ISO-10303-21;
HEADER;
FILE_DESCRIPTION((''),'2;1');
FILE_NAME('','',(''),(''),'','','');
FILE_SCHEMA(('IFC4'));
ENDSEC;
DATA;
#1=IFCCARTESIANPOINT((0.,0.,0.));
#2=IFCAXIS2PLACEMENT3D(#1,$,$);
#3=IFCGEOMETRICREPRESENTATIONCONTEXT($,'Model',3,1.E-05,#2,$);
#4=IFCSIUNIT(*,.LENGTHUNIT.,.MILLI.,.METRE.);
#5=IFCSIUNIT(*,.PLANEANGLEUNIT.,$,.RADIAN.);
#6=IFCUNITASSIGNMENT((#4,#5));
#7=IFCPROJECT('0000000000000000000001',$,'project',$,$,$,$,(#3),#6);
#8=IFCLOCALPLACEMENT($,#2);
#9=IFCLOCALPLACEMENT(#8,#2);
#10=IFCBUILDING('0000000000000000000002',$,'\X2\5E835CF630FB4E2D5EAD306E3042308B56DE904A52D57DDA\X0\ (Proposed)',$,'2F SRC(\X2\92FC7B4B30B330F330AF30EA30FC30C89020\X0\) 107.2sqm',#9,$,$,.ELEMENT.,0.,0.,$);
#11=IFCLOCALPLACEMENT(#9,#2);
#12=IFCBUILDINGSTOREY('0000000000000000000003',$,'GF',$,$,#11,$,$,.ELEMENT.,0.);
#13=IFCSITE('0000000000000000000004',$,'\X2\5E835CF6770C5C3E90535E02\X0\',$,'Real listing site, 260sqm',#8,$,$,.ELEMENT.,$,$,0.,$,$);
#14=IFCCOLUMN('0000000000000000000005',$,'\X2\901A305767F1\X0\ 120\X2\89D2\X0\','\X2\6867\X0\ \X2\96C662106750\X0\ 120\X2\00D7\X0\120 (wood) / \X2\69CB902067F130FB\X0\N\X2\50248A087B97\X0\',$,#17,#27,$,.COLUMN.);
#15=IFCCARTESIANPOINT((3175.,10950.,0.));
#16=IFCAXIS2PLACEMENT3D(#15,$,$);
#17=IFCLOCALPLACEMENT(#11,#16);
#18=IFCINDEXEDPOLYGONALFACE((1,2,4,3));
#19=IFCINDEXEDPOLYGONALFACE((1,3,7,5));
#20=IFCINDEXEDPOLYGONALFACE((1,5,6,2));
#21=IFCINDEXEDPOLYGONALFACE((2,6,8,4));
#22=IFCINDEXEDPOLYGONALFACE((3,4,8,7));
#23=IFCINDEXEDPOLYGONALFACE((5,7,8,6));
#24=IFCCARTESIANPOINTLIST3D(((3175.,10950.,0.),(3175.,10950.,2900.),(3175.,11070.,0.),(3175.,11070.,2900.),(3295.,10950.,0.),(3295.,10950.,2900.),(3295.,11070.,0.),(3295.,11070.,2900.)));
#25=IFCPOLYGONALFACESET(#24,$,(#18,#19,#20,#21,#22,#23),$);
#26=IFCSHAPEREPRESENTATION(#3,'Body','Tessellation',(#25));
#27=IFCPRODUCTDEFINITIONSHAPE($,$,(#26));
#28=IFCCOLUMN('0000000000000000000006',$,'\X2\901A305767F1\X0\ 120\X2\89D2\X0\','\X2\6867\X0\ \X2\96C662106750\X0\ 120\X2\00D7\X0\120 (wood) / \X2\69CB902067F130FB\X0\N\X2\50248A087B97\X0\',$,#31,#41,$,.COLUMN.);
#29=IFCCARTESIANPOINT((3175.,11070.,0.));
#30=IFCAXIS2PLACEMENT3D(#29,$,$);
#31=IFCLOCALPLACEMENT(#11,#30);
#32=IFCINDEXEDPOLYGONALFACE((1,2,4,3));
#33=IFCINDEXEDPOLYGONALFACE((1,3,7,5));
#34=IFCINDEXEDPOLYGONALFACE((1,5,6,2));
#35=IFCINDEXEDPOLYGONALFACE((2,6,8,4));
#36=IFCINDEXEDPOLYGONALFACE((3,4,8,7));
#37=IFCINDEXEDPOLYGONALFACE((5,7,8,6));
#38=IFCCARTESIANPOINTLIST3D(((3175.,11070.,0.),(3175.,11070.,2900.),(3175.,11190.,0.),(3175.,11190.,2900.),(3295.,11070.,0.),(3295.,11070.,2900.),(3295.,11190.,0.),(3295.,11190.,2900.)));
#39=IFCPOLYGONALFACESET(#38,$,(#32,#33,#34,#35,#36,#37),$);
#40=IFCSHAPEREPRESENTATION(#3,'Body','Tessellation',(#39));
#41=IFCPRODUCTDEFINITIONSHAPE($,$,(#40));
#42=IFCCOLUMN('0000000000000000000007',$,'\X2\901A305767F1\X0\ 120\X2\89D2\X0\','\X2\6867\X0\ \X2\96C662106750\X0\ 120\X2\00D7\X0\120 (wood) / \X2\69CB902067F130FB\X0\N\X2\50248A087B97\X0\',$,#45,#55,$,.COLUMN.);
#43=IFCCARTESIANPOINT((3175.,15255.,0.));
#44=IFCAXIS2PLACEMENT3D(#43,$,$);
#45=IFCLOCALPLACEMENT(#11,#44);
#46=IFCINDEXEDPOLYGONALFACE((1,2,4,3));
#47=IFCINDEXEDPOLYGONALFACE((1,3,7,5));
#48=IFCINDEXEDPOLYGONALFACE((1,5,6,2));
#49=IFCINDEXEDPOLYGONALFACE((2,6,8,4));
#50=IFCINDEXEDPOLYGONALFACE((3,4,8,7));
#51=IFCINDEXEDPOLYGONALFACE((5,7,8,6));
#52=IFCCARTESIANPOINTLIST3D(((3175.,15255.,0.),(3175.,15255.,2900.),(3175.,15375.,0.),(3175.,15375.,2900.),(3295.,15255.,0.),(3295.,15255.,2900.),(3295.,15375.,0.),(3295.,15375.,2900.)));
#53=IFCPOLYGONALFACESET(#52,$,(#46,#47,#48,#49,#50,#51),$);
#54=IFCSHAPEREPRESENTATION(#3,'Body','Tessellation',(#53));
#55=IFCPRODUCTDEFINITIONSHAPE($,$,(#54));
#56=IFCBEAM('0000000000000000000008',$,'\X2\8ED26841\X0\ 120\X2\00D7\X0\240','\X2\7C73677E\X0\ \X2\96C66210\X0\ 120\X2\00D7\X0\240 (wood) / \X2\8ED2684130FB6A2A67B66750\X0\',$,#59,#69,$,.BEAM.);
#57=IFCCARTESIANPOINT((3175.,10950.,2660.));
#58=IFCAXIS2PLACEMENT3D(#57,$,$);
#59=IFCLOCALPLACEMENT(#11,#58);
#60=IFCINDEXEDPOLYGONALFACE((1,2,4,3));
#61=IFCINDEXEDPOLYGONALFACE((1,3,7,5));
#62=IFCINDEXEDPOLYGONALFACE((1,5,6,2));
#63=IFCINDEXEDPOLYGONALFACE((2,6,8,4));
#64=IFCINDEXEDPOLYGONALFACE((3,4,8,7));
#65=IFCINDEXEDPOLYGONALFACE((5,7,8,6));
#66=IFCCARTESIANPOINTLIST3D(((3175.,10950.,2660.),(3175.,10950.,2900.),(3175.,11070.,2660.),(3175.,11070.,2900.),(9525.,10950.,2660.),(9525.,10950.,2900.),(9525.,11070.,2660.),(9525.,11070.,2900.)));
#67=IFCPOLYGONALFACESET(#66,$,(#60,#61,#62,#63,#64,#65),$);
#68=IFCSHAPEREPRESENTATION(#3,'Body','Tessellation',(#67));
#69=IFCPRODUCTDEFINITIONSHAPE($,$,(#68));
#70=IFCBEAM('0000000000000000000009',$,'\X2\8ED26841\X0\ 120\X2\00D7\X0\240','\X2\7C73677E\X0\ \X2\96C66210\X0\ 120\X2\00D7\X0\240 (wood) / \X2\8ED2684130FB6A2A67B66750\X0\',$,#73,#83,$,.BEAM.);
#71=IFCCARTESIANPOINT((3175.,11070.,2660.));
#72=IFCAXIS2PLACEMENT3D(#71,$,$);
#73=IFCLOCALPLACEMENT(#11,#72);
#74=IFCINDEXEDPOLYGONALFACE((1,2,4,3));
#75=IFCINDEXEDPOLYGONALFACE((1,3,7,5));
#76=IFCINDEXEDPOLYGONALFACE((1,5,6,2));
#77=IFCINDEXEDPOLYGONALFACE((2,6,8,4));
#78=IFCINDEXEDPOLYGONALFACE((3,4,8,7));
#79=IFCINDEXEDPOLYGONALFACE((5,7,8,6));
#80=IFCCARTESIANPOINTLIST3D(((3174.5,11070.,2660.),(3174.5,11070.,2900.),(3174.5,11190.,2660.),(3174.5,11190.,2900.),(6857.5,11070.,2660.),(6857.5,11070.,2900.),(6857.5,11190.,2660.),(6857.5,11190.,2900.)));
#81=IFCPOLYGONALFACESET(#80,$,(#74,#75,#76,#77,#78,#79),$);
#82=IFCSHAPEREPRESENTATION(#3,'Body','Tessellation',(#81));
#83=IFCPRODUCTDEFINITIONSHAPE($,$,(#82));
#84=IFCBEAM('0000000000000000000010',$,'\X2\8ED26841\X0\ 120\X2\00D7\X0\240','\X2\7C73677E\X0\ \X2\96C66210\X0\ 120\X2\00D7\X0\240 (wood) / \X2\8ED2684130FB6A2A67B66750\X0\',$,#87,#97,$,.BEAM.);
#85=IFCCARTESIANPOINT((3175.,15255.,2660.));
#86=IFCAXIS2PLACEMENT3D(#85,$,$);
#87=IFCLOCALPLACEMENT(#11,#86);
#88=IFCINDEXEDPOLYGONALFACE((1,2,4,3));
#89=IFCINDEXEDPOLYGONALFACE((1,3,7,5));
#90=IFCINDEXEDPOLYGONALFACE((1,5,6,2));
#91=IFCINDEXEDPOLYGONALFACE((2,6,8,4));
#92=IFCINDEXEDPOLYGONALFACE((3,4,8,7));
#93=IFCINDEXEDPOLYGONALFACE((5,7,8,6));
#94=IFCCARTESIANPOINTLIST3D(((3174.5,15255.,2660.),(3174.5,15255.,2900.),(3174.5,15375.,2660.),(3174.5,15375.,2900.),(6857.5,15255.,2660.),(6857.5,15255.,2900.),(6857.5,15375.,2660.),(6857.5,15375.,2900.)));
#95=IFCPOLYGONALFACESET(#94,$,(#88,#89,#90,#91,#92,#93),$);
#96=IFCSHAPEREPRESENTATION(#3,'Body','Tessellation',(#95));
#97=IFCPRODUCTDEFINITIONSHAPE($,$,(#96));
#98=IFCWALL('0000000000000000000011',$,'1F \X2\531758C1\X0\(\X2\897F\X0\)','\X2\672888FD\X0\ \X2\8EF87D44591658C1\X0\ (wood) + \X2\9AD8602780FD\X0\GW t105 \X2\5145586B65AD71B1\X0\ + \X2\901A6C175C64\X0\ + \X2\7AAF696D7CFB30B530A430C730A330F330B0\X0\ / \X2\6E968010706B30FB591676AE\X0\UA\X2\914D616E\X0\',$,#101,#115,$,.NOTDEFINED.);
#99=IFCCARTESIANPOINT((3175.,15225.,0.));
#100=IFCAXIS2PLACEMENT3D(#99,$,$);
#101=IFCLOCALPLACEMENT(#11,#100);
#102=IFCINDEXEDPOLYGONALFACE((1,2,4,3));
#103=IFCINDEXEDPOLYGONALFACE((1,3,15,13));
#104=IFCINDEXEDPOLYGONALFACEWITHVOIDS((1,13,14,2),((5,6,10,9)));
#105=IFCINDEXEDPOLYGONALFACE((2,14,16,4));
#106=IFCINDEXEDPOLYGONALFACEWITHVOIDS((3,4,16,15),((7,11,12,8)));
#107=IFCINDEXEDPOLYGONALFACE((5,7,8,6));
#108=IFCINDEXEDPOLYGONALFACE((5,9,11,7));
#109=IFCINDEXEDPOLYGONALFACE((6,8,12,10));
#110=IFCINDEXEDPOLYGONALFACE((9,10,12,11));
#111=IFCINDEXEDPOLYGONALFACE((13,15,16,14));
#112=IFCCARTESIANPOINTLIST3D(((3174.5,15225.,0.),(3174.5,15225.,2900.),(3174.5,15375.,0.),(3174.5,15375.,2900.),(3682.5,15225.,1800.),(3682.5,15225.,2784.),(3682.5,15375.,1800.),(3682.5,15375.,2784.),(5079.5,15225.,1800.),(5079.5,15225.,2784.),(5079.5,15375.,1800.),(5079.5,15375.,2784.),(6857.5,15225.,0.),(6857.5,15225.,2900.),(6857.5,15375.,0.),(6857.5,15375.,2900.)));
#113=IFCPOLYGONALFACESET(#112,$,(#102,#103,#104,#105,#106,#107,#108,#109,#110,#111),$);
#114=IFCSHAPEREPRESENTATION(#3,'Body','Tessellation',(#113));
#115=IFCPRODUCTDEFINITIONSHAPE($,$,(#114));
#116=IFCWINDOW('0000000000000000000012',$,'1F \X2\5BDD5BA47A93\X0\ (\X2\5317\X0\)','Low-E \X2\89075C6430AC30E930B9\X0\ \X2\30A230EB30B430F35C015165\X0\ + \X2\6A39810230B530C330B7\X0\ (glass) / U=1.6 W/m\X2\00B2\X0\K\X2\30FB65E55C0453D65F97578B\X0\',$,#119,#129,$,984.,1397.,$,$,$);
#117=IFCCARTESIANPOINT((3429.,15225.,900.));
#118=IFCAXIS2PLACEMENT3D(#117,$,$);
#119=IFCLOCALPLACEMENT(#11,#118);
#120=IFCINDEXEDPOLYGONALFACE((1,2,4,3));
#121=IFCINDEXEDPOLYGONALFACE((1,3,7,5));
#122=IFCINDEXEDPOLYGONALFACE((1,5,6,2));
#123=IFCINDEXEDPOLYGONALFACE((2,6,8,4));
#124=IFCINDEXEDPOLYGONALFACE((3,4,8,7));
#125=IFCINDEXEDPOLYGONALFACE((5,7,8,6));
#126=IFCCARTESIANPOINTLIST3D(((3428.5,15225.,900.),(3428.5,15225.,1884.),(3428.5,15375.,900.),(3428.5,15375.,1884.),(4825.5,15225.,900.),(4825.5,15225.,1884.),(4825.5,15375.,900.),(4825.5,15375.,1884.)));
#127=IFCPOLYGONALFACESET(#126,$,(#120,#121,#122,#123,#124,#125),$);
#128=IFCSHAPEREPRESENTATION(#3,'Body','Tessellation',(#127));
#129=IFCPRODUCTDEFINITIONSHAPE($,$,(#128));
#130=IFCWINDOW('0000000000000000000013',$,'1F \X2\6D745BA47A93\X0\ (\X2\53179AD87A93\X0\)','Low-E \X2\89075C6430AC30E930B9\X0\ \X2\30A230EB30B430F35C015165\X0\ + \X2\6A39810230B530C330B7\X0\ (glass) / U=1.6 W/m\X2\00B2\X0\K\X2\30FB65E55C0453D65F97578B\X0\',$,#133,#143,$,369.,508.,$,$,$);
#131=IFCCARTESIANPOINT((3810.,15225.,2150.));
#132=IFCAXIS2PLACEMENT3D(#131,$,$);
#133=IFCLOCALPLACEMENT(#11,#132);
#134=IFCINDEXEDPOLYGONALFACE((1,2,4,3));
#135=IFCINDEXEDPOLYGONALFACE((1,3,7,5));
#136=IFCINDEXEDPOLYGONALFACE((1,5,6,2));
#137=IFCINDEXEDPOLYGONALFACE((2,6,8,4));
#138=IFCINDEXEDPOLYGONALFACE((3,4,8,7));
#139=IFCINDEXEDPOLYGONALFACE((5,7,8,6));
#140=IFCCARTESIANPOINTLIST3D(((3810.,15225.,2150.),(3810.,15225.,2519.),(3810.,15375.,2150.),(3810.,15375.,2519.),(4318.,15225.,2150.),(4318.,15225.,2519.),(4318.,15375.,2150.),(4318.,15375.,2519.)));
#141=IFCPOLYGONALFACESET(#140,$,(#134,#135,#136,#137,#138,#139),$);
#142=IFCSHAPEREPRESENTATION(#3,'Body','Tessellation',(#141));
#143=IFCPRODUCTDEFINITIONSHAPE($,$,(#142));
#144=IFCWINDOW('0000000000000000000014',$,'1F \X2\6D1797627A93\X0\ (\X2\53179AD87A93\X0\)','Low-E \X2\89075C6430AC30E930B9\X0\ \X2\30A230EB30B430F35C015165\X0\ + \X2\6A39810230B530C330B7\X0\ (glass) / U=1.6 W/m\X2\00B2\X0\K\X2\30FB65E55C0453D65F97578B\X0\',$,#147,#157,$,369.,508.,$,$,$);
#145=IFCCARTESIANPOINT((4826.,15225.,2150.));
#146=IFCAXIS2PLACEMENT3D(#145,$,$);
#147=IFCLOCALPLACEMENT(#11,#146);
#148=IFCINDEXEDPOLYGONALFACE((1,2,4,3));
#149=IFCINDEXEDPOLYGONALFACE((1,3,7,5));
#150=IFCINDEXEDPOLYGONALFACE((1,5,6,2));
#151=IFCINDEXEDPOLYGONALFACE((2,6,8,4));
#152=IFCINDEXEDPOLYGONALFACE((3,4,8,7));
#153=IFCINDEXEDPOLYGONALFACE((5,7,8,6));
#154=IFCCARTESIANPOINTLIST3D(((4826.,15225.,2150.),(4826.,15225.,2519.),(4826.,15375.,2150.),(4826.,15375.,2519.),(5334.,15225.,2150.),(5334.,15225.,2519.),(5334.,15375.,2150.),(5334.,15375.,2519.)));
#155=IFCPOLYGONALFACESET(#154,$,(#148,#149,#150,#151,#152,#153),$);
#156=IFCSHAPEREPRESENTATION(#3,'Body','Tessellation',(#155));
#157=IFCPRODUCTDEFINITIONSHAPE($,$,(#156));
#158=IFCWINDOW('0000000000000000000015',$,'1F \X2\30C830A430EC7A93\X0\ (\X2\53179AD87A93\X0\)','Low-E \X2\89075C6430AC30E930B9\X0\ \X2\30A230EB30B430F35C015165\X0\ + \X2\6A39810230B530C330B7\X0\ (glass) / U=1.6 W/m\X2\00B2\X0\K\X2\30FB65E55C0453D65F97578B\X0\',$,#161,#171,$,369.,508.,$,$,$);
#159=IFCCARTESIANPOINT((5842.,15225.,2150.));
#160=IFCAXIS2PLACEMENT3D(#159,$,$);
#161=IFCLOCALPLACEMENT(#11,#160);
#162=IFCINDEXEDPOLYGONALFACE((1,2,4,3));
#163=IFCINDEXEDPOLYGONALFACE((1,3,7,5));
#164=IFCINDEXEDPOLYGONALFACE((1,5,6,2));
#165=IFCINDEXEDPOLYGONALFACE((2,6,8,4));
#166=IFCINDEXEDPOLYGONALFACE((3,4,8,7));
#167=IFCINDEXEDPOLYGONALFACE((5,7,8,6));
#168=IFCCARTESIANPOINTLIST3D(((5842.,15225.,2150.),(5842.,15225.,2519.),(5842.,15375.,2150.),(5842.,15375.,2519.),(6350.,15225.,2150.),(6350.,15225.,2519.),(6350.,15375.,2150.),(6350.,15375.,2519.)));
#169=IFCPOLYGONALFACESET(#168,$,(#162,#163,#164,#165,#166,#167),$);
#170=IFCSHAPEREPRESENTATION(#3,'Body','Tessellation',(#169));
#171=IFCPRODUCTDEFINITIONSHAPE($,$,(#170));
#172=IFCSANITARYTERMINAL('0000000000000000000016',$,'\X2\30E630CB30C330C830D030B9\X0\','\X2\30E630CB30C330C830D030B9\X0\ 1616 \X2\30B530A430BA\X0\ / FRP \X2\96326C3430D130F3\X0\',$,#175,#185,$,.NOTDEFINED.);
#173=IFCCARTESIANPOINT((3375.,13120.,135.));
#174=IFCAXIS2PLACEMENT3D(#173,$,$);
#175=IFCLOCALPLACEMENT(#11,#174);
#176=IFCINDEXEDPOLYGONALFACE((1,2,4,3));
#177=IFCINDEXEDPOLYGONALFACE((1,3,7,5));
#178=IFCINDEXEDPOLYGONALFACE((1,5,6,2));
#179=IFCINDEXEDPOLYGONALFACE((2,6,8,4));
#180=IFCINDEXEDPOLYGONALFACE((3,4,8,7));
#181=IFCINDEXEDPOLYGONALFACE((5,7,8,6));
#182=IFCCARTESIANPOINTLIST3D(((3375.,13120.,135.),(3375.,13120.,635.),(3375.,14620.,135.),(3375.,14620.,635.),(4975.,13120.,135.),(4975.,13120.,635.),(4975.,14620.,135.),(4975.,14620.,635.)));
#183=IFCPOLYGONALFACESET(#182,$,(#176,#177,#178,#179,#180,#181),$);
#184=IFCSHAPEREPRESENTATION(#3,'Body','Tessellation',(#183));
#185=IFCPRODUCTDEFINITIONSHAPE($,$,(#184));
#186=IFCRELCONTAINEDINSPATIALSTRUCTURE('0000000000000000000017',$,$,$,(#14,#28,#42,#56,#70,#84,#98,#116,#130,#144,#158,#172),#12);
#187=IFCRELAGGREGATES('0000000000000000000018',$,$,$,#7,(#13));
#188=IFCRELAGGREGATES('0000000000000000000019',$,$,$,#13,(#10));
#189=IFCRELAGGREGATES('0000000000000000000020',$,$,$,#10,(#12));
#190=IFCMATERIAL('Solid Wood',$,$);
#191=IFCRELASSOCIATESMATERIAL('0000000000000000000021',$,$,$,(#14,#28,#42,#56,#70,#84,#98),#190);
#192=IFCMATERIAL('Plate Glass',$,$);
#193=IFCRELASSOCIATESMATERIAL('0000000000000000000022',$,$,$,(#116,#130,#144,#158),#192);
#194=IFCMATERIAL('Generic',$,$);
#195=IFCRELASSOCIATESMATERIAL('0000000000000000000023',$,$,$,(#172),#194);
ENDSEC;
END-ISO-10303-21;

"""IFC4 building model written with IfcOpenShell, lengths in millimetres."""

from ifc_helpers import new_model, si_unit, frame, frame_2d, origin, place, context, project, spatial, rectangle, extrude, material, element, fill, save


model = new_model("IFC4")

# Units and contexts
model_context = context("Model", 3, precision=1e-05, world=origin())
ifc_project = project(units=[si_unit("LENGTHUNIT", "METRE", prefix="MILLI"), si_unit("PLANEANGLEUNIT", "RADIAN")], contexts=[model_context])

# Site, building, storey
site_placement = place(None, origin())
site = spatial("IfcSite", under=ifc_project, at=site_placement, Name="広島県尾道市", ObjectType="Real listing site, 260sqm", CompositionType="ELEMENT", RefElevation=0.0)
building_placement = place(site_placement, origin())
building = spatial("IfcBuilding", under=site, at=building_placement, Name="広島・中庭のある回遊動線 (Proposed)", ObjectType="2F SRC(鋼筋コンクリート造) 107.2sqm", CompositionType="ELEMENT", ElevationOfRefHeight=0.0, ElevationOfTerrain=0.0)
storey_placement = place(building_placement, origin())
storey = spatial("IfcBuildingStorey", under=building, at=storey_placement, Name="GF", CompositionType="ELEMENT", Elevation=0.0)

# Columns
ifc_material_1 = material(Name="Solid Wood")
column_1_placement = place(storey_placement, frame((3175.0, 10950.0, 0.0)))
element("IfcColumn", 1, at=column_1_placement, inside=storey, material=ifc_material_1, Name="通し柱 120角", Description="桧 集成材 120×120 (wood) / 構造柱・N値計算", PredefinedType="COLUMN", context=model_context, shape_type="SweptSolid", body=[
    extrude(rectangle(XDim=120.0, YDim=120.0, at=frame_2d((60.0, 60.0))), frame((3175.0, 10950.0, 0.0)), (0.0, 0.0, 1.0), 2900.0),
])
column_2_placement = place(storey_placement, frame((3175.0, 11070.0, 0.0)))
element("IfcColumn", 2, at=column_2_placement, inside=storey, material=ifc_material_1, Name="通し柱 120角", Description="桧 集成材 120×120 (wood) / 構造柱・N値計算", PredefinedType="COLUMN", context=model_context, shape_type="SweptSolid", body=[
    extrude(rectangle(XDim=120.0, YDim=120.0, at=frame_2d((60.0, 60.0))), frame((3175.0, 11070.0, 0.0)), (0.0, 0.0, 1.0), 2900.0),
])
column_3_placement = place(storey_placement, frame((3175.0, 15255.0, 0.0)))
element("IfcColumn", 3, at=column_3_placement, inside=storey, material=ifc_material_1, Name="通し柱 120角", Description="桧 集成材 120×120 (wood) / 構造柱・N値計算", PredefinedType="COLUMN", context=model_context, shape_type="SweptSolid", body=[
    extrude(rectangle(XDim=120.0, YDim=120.0, at=frame_2d((60.0, 60.0))), frame((3175.0, 15255.0, 0.0)), (0.0, 0.0, 1.0), 2900.0),
])

# Beams
beam_1_placement = place(storey_placement, frame((3175.0, 10950.0, 2660.0)))
element("IfcBeam", 4, at=beam_1_placement, inside=storey, material=ifc_material_1, Name="軒桁 120×240", Description="米松 集成 120×240 (wood) / 軒桁・横架材", PredefinedType="BEAM", context=model_context, shape_type="SweptSolid", body=[
    extrude(rectangle(XDim=6350.0, YDim=120.0, at=frame_2d((3175.0, 60.0))), frame((3175.0, 10950.0, 2660.0)), (0.0, 0.0, 1.0), 240.0),
])
beam_2_placement = place(storey_placement, frame((3175.0, 11070.0, 2660.0)))
element("IfcBeam", 5, at=beam_2_placement, inside=storey, material=ifc_material_1, Name="軒桁 120×240", Description="米松 集成 120×240 (wood) / 軒桁・横架材", PredefinedType="BEAM", context=model_context, shape_type="SweptSolid", body=[
    extrude(rectangle(XDim=3683.0, YDim=120.0, at=frame_2d((1841.0, 60.0))), frame((3175.0, 11070.0, 2660.0)), (0.0, 0.0, 1.0), 240.0),
])
beam_3_placement = place(storey_placement, frame((3175.0, 15255.0, 2660.0)))
element("IfcBeam", 6, at=beam_3_placement, inside=storey, material=ifc_material_1, Name="軒桁 120×240", Description="米松 集成 120×240 (wood) / 軒桁・横架材", PredefinedType="BEAM", context=model_context, shape_type="SweptSolid", body=[
    extrude(rectangle(XDim=3683.0, YDim=120.0, at=frame_2d((1841.0, 60.0))), frame((3175.0, 15255.0, 2660.0)), (0.0, 0.0, 1.0), 240.0),
])

# Wall, openings, windows
wall_1_placement = place(storey_placement, frame((3175.0, 15225.0, 0.0)))
wall_1 = element("IfcWall", 7, at=wall_1_placement, inside=storey, material=ifc_material_1, Name="1F 北壁(西)", Description="木製 軸組外壁 (wood) + 高性能GW t105 充填断熱 + 通気層 + 窯業系サイディング / 準耐火・外皮UA配慮", PredefinedType="NOTDEFINED", context=model_context, shape_type="SweptSolid", body=[
    extrude(rectangle(XDim=3683.0, YDim=150.0, at=frame_2d((1841.0, 75.0))), frame((3175.0, 15225.0, 0.0)), (0.0, 0.0, 1.0), 2900.0),
])
opening_1_placement = place(storey_placement, frame((3429.0, 15225.0, 900.0)))
opening_1 = element("IfcOpeningElement", 8, at=opening_1_placement, cuts=wall_1, PredefinedType="NOTDEFINED", context=model_context, shape_type="SweptSolid", body=[
    extrude(rectangle(XDim=1397.0, YDim=150.0, at=frame_2d((698.0, 75.0))), frame((3429.0, 15225.0, 900.0)), (0.0, 0.0, 1.0), 984.0),
])
opening_2_placement = place(storey_placement, frame((3810.0, 15225.0, 2150.0)))
opening_2 = element("IfcOpeningElement", 9, at=opening_2_placement, cuts=wall_1, PredefinedType="NOTDEFINED", context=model_context, shape_type="SweptSolid", body=[
    extrude(rectangle(XDim=508.0, YDim=150.0, at=frame_2d((254.0, 75.0))), frame((3810.0, 15225.0, 2150.0)), (0.0, 0.0, 1.0), 369.0),
])
opening_3_placement = place(storey_placement, frame((4826.0, 15225.0, 2150.0)))
opening_3 = element("IfcOpeningElement", 10, at=opening_3_placement, cuts=wall_1, PredefinedType="NOTDEFINED", context=model_context, shape_type="SweptSolid", body=[
    extrude(rectangle(XDim=508.0, YDim=150.0, at=frame_2d((254.0, 75.0))), frame((4826.0, 15225.0, 2150.0)), (0.0, 0.0, 1.0), 369.0),
])
opening_4_placement = place(storey_placement, frame((5842.0, 15225.0, 2150.0)))
opening_4 = element("IfcOpeningElement", 11, at=opening_4_placement, cuts=wall_1, PredefinedType="NOTDEFINED", context=model_context, shape_type="SweptSolid", body=[
    extrude(rectangle(XDim=508.0, YDim=150.0, at=frame_2d((254.0, 75.0))), frame((5842.0, 15225.0, 2150.0)), (0.0, 0.0, 1.0), 369.0),
])
ifc_material_2 = material(Name="Plate Glass")
window_1_placement = place(storey_placement, frame((3429.0, 15225.0, 900.0)))
window_1 = element("IfcWindow", 12, at=window_1_placement, inside=storey, material=ifc_material_2, Name="1F 寝室窓 (北)", Description="Low-E 複層ガラス アルゴン封入 + 樹脂サッシ (glass) / U=1.6 W/m²K・日射取得型", OverallHeight=984.0, OverallWidth=1397.0, context=model_context, shape_type="SweptSolid", body=[
    extrude(rectangle(XDim=1397.0, YDim=150.0, at=frame_2d((698.0, 75.0))), frame((3429.0, 15225.0, 900.0)), (0.0, 0.0, 1.0), 984.0),
])
fill(opening_1, window_1)
window_2_placement = place(storey_placement, frame((3810.0, 15225.0, 2150.0)))
window_2 = element("IfcWindow", 13, at=window_2_placement, inside=storey, material=ifc_material_2, Name="1F 浴室窓 (北高窓)", Description="Low-E 複層ガラス アルゴン封入 + 樹脂サッシ (glass) / U=1.6 W/m²K・日射取得型", OverallHeight=369.0, OverallWidth=508.0, context=model_context, shape_type="SweptSolid", body=[
    extrude(rectangle(XDim=508.0, YDim=150.0, at=frame_2d((254.0, 75.0))), frame((3810.0, 15225.0, 2150.0)), (0.0, 0.0, 1.0), 369.0),
])
fill(opening_2, window_2)
window_3_placement = place(storey_placement, frame((4826.0, 15225.0, 2150.0)))
window_3 = element("IfcWindow", 14, at=window_3_placement, inside=storey, material=ifc_material_2, Name="1F 洗面窓 (北高窓)", Description="Low-E 複層ガラス アルゴン封入 + 樹脂サッシ (glass) / U=1.6 W/m²K・日射取得型", OverallHeight=369.0, OverallWidth=508.0, context=model_context, shape_type="SweptSolid", body=[
    extrude(rectangle(XDim=508.0, YDim=150.0, at=frame_2d((254.0, 75.0))), frame((4826.0, 15225.0, 2150.0)), (0.0, 0.0, 1.0), 369.0),
])
fill(opening_3, window_3)
window_4_placement = place(storey_placement, frame((5842.0, 15225.0, 2150.0)))
window_4 = element("IfcWindow", 15, at=window_4_placement, inside=storey, material=ifc_material_2, Name="1F トイレ窓 (北高窓)", Description="Low-E 複層ガラス アルゴン封入 + 樹脂サッシ (glass) / U=1.6 W/m²K・日射取得型", OverallHeight=369.0, OverallWidth=508.0, context=model_context, shape_type="SweptSolid", body=[
    extrude(rectangle(XDim=508.0, YDim=150.0, at=frame_2d((254.0, 75.0))), frame((5842.0, 15225.0, 2150.0)), (0.0, 0.0, 1.0), 369.0),
])
fill(opening_4, window_4)

# Shared definitions
ifc_material_3 = material(Name="Generic")

# Sanitary terminal
sanitary_terminal_placement = place(storey_placement, frame((3375.0, 13120.0, 135.0)))
element("IfcSanitaryTerminal", 16, at=sanitary_terminal_placement, inside=storey, material=ifc_material_3, Name="ユニットバス", Description="ユニットバス 1616 サイズ / FRP 防水パン", PredefinedType="NOTDEFINED", context=model_context, shape_type="SweptSolid", body=[
    extrude(rectangle(XDim=1600.0, YDim=1500.0, at=frame_2d((800.0, 750.0))), frame((3375.0, 13120.0, 135.0)), (0.0, 0.0, 1.0), 500.0),
])

save(model, "model.ifc")
